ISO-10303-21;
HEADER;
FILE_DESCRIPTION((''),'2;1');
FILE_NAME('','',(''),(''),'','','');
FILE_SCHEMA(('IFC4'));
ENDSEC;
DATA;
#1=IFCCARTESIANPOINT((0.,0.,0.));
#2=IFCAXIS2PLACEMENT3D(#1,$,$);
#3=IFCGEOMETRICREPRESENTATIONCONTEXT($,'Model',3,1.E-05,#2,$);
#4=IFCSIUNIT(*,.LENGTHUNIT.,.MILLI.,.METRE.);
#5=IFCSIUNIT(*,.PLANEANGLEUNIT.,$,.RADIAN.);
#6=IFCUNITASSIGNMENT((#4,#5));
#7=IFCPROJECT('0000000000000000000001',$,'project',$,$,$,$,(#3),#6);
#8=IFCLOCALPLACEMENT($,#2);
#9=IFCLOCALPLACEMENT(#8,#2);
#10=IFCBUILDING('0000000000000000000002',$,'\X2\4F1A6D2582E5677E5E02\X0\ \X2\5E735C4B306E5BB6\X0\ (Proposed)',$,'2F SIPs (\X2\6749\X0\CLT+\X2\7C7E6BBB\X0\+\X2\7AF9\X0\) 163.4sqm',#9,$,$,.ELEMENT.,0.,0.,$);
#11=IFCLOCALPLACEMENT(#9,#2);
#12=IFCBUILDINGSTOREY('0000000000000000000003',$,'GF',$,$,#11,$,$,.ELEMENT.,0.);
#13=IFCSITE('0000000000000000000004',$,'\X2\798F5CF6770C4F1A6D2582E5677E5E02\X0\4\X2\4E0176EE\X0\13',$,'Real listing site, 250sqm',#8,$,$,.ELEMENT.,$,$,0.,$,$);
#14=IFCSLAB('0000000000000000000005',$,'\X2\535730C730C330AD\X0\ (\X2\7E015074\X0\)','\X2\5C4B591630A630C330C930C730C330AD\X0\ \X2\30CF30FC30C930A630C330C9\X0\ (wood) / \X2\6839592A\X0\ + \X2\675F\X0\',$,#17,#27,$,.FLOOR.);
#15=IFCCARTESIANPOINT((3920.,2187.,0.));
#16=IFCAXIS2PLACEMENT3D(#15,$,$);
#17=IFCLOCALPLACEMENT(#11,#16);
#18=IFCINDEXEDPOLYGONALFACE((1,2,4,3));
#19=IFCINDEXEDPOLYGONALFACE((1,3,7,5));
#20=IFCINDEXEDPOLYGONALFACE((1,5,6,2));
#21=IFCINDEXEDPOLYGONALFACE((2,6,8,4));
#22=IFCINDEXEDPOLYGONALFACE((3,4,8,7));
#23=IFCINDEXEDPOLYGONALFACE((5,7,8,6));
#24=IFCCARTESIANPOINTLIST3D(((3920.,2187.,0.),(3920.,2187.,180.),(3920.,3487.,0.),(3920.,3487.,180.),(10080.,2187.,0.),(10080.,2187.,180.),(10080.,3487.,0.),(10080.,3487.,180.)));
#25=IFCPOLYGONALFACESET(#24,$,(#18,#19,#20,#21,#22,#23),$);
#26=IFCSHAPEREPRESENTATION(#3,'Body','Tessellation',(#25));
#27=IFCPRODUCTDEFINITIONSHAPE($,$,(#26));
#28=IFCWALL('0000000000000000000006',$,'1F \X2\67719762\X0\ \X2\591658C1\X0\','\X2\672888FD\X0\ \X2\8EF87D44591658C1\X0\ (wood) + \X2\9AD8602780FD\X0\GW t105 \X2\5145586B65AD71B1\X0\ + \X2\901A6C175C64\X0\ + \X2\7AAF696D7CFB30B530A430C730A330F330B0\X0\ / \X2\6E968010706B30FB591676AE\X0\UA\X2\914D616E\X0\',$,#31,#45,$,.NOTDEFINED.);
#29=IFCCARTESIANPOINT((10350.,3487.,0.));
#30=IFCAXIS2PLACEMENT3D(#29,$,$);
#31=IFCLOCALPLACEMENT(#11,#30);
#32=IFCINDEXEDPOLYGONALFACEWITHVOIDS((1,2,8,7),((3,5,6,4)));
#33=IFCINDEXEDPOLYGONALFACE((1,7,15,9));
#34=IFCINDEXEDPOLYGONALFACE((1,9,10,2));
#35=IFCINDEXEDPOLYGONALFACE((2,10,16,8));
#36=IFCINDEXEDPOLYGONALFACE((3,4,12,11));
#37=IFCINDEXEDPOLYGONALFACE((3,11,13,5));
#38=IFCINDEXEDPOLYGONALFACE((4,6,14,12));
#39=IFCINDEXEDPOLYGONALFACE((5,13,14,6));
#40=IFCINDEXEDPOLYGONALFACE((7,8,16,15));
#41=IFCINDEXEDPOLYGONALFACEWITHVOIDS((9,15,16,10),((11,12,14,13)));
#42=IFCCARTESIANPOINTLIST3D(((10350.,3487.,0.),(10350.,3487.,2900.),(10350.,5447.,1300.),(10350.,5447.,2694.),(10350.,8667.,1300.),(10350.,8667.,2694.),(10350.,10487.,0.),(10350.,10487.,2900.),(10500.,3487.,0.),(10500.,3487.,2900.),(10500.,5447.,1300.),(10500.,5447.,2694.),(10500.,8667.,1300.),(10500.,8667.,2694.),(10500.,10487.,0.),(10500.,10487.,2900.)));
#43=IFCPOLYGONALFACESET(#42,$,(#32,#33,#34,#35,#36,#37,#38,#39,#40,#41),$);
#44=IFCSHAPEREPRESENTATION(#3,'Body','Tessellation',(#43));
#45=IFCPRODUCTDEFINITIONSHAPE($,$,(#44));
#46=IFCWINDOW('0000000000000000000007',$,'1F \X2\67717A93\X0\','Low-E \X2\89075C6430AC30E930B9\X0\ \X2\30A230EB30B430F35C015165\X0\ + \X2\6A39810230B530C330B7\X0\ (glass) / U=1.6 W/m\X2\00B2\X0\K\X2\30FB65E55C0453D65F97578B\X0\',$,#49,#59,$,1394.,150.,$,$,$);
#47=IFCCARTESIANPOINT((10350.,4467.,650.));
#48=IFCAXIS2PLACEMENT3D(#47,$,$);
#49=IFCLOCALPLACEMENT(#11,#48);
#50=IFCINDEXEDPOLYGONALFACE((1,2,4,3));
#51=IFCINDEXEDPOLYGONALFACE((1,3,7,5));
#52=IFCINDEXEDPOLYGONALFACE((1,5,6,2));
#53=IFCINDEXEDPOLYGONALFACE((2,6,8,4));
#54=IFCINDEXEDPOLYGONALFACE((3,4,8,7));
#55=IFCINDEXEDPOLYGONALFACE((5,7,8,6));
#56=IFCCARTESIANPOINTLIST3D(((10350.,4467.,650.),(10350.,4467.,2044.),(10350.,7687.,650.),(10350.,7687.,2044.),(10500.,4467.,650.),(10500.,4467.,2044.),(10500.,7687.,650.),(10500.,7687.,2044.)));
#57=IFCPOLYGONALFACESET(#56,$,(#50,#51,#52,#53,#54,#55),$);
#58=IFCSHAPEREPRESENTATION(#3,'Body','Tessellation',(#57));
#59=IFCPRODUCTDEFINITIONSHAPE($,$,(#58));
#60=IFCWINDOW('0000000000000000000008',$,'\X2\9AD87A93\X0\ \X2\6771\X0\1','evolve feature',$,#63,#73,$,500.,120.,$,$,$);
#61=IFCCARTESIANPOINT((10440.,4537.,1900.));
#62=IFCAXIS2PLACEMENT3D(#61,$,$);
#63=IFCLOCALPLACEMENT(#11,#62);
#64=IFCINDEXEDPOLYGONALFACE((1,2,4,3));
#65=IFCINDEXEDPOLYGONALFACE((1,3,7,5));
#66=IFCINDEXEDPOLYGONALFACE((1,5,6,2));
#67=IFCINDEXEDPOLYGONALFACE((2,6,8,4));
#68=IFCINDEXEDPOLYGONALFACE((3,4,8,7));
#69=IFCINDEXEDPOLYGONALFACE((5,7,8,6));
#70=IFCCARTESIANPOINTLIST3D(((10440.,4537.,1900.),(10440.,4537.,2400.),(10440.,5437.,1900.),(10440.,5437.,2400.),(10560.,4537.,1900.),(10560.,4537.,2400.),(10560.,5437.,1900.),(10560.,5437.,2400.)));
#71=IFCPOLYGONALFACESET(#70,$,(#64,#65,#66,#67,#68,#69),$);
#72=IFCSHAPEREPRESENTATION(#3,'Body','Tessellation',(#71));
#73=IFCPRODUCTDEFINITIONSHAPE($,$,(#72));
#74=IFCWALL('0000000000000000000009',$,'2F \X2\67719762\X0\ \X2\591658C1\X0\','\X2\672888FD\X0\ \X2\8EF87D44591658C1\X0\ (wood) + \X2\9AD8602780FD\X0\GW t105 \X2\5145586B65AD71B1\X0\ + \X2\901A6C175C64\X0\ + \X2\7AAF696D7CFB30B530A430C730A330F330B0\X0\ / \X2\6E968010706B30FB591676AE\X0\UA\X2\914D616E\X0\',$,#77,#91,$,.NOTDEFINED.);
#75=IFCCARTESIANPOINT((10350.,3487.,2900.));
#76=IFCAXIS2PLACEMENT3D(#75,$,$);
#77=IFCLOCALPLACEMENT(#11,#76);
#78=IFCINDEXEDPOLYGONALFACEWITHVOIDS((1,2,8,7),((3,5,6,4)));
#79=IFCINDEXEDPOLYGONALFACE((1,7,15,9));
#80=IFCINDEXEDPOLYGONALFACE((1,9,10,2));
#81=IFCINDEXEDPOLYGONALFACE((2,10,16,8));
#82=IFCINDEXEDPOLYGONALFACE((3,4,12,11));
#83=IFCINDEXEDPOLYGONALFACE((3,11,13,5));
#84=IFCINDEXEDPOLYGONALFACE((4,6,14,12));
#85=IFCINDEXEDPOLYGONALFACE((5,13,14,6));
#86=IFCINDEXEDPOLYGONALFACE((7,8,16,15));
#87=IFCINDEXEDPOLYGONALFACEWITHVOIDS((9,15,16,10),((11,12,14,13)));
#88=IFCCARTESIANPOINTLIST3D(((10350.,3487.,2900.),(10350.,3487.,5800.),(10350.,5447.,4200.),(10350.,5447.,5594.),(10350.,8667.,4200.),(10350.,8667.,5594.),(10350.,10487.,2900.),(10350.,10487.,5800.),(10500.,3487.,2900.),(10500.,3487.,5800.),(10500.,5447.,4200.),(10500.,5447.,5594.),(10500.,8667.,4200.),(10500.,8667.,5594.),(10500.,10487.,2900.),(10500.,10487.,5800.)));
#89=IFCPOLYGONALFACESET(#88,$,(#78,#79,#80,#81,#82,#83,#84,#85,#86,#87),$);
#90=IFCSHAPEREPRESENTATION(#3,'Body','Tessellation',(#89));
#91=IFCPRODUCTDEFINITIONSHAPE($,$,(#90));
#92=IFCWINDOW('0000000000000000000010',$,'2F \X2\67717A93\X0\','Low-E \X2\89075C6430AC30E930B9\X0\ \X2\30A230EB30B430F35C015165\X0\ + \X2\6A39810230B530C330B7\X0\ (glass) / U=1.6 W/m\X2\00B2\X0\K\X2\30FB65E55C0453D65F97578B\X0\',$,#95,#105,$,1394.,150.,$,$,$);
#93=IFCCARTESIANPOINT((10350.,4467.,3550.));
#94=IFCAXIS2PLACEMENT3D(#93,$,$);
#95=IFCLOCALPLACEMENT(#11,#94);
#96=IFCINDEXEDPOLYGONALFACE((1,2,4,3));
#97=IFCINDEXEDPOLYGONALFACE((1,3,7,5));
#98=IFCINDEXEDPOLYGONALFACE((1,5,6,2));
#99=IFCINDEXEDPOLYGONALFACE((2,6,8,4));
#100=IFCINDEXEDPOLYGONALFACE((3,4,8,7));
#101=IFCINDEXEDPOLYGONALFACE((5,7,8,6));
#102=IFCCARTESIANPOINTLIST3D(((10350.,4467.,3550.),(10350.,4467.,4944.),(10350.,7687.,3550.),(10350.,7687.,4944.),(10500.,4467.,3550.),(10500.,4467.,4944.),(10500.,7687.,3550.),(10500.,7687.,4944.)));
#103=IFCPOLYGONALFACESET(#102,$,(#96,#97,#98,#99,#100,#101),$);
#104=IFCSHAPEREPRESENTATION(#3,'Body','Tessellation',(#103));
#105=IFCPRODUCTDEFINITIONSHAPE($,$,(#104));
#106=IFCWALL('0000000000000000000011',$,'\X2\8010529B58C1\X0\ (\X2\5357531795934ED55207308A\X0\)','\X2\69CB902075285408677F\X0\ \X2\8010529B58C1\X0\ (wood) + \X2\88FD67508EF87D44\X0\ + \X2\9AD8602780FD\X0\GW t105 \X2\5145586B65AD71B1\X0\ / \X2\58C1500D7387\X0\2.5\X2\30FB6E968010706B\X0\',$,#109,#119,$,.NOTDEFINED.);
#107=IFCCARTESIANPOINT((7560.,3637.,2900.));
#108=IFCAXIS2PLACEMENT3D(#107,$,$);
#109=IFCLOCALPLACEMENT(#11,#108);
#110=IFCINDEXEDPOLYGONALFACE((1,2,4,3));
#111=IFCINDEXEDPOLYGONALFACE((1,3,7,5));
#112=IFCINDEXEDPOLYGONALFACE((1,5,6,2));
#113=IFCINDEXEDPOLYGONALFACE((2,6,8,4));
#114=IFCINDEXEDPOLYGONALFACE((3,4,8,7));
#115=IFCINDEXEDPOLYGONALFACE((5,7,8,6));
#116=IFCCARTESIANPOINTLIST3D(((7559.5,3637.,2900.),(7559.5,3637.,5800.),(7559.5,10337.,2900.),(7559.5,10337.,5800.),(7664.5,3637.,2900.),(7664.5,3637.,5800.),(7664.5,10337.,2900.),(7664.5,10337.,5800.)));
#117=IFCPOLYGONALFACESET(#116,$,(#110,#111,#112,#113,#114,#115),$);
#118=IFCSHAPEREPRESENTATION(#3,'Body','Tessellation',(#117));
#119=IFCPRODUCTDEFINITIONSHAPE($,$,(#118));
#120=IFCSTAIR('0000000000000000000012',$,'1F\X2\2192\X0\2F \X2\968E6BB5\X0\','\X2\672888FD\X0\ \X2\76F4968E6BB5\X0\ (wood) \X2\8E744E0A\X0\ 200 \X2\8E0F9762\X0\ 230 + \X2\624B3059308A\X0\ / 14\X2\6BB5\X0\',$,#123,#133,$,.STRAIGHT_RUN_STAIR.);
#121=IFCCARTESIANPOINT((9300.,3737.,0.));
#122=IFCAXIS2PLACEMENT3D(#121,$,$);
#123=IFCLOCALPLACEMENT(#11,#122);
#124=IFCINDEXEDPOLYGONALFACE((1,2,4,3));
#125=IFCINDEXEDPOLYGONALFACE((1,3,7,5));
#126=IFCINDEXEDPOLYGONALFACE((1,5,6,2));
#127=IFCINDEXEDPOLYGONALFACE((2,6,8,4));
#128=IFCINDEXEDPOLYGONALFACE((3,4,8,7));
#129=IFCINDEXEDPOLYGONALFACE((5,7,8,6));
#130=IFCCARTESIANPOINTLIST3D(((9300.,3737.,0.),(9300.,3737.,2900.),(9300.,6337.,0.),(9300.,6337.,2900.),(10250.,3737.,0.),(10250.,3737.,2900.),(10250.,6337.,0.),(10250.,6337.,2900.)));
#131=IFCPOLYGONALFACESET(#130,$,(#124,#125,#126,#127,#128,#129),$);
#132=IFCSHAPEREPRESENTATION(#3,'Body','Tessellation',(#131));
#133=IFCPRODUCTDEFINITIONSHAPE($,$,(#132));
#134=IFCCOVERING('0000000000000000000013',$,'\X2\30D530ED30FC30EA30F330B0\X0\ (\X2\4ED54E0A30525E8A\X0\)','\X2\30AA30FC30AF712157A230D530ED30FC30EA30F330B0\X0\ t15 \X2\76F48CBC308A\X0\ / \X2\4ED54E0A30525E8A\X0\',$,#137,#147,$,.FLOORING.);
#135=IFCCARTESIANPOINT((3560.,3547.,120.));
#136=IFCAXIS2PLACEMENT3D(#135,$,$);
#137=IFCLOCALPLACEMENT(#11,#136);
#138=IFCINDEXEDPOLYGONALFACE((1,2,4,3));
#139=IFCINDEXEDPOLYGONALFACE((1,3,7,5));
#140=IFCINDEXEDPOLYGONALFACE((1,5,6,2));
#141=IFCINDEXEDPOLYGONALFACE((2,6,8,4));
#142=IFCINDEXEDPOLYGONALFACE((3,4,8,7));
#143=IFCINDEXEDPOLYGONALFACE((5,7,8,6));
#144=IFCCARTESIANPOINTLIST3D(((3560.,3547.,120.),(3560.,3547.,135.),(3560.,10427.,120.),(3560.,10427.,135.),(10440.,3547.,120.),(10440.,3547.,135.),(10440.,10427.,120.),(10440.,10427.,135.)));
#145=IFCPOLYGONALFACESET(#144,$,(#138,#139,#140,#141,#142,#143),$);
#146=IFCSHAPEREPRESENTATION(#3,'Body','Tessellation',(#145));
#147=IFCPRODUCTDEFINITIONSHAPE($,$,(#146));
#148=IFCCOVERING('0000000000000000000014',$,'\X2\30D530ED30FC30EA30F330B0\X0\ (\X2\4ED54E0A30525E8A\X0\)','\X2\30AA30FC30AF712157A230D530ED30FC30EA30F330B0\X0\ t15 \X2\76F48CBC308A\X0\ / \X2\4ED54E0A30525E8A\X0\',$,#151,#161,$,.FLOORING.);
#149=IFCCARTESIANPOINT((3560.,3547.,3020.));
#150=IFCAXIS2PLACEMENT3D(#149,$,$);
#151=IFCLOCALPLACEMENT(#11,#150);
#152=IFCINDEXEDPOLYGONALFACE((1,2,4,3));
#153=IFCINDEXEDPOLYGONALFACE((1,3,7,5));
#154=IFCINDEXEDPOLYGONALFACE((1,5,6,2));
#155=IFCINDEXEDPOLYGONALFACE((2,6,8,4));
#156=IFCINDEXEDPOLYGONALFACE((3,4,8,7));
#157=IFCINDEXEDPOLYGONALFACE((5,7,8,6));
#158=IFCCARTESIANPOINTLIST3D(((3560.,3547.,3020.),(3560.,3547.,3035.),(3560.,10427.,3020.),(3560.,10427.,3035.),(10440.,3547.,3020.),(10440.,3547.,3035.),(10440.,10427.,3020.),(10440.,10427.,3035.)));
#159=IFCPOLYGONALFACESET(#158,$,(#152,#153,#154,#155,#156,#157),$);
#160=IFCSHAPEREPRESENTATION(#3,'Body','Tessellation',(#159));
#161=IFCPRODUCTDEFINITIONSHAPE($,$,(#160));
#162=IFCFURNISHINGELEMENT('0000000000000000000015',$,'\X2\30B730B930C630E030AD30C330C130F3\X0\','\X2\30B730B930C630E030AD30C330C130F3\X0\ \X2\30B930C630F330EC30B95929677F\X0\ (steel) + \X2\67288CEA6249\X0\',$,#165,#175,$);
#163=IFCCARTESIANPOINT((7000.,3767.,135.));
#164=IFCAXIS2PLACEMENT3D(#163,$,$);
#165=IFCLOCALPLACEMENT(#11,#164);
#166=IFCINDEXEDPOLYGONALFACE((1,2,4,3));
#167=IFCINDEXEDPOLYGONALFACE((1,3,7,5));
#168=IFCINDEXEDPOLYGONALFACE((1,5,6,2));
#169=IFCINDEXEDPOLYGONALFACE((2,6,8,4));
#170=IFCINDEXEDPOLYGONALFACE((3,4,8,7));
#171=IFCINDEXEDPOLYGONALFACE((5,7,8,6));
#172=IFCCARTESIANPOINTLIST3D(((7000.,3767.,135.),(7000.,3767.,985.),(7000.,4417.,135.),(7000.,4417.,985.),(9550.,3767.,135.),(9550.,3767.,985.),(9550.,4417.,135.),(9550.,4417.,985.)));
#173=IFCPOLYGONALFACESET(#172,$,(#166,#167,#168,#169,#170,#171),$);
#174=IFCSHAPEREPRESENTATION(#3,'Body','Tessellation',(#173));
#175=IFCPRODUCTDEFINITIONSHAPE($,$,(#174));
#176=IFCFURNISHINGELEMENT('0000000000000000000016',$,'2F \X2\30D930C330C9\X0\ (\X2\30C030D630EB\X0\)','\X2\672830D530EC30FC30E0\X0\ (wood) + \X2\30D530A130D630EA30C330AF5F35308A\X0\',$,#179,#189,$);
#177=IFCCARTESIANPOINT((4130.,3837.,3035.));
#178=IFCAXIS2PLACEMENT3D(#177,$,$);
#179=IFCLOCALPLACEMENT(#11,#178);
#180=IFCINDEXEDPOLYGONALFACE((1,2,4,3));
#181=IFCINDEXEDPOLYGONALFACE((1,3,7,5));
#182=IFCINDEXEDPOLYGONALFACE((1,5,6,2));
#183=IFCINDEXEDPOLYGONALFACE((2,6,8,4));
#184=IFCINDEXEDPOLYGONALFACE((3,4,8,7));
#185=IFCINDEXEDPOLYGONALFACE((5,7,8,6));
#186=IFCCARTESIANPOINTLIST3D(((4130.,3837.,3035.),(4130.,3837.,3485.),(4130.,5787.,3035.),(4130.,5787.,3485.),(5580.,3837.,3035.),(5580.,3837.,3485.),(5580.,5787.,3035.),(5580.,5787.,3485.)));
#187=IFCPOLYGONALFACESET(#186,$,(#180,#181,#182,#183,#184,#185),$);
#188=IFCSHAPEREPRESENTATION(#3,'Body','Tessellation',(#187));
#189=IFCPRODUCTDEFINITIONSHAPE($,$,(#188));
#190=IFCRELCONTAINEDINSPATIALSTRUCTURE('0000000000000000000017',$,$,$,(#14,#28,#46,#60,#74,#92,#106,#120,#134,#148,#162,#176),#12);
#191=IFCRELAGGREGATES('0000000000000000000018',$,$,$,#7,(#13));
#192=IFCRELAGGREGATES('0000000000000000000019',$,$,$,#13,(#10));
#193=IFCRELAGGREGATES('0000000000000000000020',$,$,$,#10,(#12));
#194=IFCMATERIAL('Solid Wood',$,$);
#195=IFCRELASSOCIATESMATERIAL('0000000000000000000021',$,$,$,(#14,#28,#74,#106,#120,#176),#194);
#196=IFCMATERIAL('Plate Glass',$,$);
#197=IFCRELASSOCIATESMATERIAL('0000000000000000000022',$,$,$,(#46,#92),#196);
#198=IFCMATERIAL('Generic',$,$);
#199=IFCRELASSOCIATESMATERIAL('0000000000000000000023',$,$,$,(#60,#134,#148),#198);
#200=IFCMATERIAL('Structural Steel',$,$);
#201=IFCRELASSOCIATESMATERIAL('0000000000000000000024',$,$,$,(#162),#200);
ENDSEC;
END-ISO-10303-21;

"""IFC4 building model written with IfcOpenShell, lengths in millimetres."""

from ifc_helpers import new_model, si_unit, frame, frame_2d, origin, place, context, project, spatial, rectangle, extrude, material, element, fill, save


model = new_model("IFC4")

# Units and contexts
model_context = context("Model", 3, precision=1e-05, world=origin())
ifc_project = project(units=[si_unit("LENGTHUNIT", "METRE", prefix="MILLI"), si_unit("PLANEANGLEUNIT", "RADIAN")], contexts=[model_context])

# Site, building, storey
site_placement = place(None, origin())
site = spatial("IfcSite", under=ifc_project, at=site_placement, Name="福島県会津若松市4丁目13", ObjectType="Real listing site, 250sqm", CompositionType="ELEMENT", RefElevation=0.0)
building_placement = place(site_placement, origin())
building = spatial("IfcBuilding", under=site, at=building_placement, Name="会津若松市 平屋の家 (Proposed)", ObjectType="2F SIPs (杉CLT+籾殻+竹) 163.4sqm", CompositionType="ELEMENT", ElevationOfRefHeight=0.0, ElevationOfTerrain=0.0)
storey_placement = place(building_placement, origin())
storey = spatial("IfcBuildingStorey", under=building, at=storey_placement, Name="GF", CompositionType="ELEMENT", Elevation=0.0)

# Slab
ifc_material_1 = material(Name="Solid Wood")
slab_placement = place(storey_placement, frame((3920.0, 2187.0, 0.0)))
element("IfcSlab", 1, at=slab_placement, inside=storey, material=ifc_material_1, Name="南デッキ (縁側)", Description="屋外ウッドデッキ ハードウッド (wood) / 根太 + 束", PredefinedType="FLOOR", context=model_context, shape_type="SweptSolid", body=[
    extrude(rectangle(XDim=6160.0, YDim=1300.0, at=frame_2d((3080.0, 650.0))), frame((3920.0, 2187.0, 0.0)), (0.0, 0.0, 1.0), 180.0),
])

# Wall, openings, windows
wall_1_placement = place(storey_placement, frame((10350.0, 3487.0, 0.0)))
wall_1 = element("IfcWall", 2, at=wall_1_placement, inside=storey, material=ifc_material_1, Name="1F 東面 外壁", Description="木製 軸組外壁 (wood) + 高性能GW t105 充填断熱 + 通気層 + 窯業系サイディング / 準耐火・外皮UA配慮", PredefinedType="NOTDEFINED", context=model_context, shape_type="SweptSolid", body=[
    extrude(rectangle(XDim=150.0, YDim=7000.0, at=frame_2d((75.0, 3500.0))), frame((10350.0, 3487.0, 0.0)), (0.0, 0.0, 1.0), 2900.0),
])
opening_1_placement = place(storey_placement, frame((10350.0, 4467.0, 650.0)))
opening_1 = element("IfcOpeningElement", 3, at=opening_1_placement, cuts=wall_1, PredefinedType="NOTDEFINED", context=model_context, shape_type="SweptSolid", body=[
    extrude(rectangle(XDim=150.0, YDim=3220.0, at=frame_2d((75.0, 1610.0))), frame((10350.0, 4467.0, 650.0)), (0.0, 0.0, 1.0), 1394.0),
])
opening_2_placement = place(storey_placement, frame((10440.0, 4537.0, 1900.0)))
opening_2 = element("IfcOpeningElement", 4, at=opening_2_placement, cuts=wall_1, PredefinedType="NOTDEFINED", context=model_context, shape_type="SweptSolid", body=[
    extrude(rectangle(XDim=120.0, YDim=900.0, at=frame_2d((60.0, 450.0))), frame((10440.0, 4537.0, 1900.0)), (0.0, 0.0, 1.0), 500.0),
])
ifc_material_2 = material(Name="Plate Glass")
window_1_placement = place(storey_placement, frame((10350.0, 4467.0, 650.0)))
window_1 = element("IfcWindow", 5, at=window_1_placement, inside=storey, material=ifc_material_2, Name="1F 東窓", Description="Low-E 複層ガラス アルゴン封入 + 樹脂サッシ (glass) / U=1.6 W/m²K・日射取得型", OverallHeight=1394.0, OverallWidth=150.0, context=model_context, shape_type="SweptSolid", body=[
    extrude(rectangle(XDim=150.0, YDim=3220.0, at=frame_2d((75.0, 1610.0))), frame((10350.0, 4467.0, 650.0)), (0.0, 0.0, 1.0), 1394.0),
])
fill(opening_1, window_1)
ifc_material_3 = material(Name="Generic")
window_2_placement = place(storey_placement, frame((10440.0, 4537.0, 1900.0)))
window_2 = element("IfcWindow", 6, at=window_2_placement, inside=storey, material=ifc_material_3, Name="高窓 東1", Description="evolve feature", OverallHeight=500.0, OverallWidth=120.0, context=model_context, shape_type="SweptSolid", body=[
    extrude(rectangle(XDim=120.0, YDim=900.0, at=frame_2d((60.0, 450.0))), frame((10440.0, 4537.0, 1900.0)), (0.0, 0.0, 1.0), 500.0),
])
fill(opening_2, window_2)

# Wall, opening, window
wall_2_placement = place(storey_placement, frame((10350.0, 3487.0, 2900.0)))
wall_2 = element("IfcWall", 7, at=wall_2_placement, inside=storey, material=ifc_material_1, Name="2F 東面 外壁", Description="木製 軸組外壁 (wood) + 高性能GW t105 充填断熱 + 通気層 + 窯業系サイディング / 準耐火・外皮UA配慮", PredefinedType="NOTDEFINED", context=model_context, shape_type="SweptSolid", body=[
    extrude(rectangle(XDim=150.0, YDim=7000.0, at=frame_2d((75.0, 3500.0))), frame((10350.0, 3487.0, 2900.0)), (0.0, 0.0, 1.0), 2900.0),
])
opening_3_placement = place(storey_placement, frame((10350.0, 4467.0, 3550.0)))
opening_3 = element("IfcOpeningElement", 8, at=opening_3_placement, cuts=wall_2, PredefinedType="NOTDEFINED", context=model_context, shape_type="SweptSolid", body=[
    extrude(rectangle(XDim=150.0, YDim=3220.0, at=frame_2d((75.0, 1610.0))), frame((10350.0, 4467.0, 3550.0)), (0.0, 0.0, 1.0), 1394.0),
])
window_3_placement = place(storey_placement, frame((10350.0, 4467.0, 3550.0)))
window_3 = element("IfcWindow", 9, at=window_3_placement, inside=storey, material=ifc_material_2, Name="2F 東窓", Description="Low-E 複層ガラス アルゴン封入 + 樹脂サッシ (glass) / U=1.6 W/m²K・日射取得型", OverallHeight=1394.0, OverallWidth=150.0, context=model_context, shape_type="SweptSolid", body=[
    extrude(rectangle(XDim=150.0, YDim=3220.0, at=frame_2d((75.0, 1610.0))), frame((10350.0, 4467.0, 3550.0)), (0.0, 0.0, 1.0), 1394.0),
])
fill(opening_3, window_3)

# Wall
wall_3_placement = place(storey_placement, frame((7560.0, 3637.0, 2900.0)))
element("IfcWall", 10, at=wall_3_placement, inside=storey, material=ifc_material_1, Name="耐力壁 (南北間仕切り)", Description="構造用合板 耐力壁 (wood) + 製材軸組 + 高性能GW t105 充填断熱 / 壁倍率2.5・準耐火", PredefinedType="NOTDEFINED", context=model_context, shape_type="SweptSolid", body=[
    extrude(rectangle(XDim=105.0, YDim=6700.0, at=frame_2d((52.0, 3350.0))), frame((7560.0, 3637.0, 2900.0)), (0.0, 0.0, 1.0), 2900.0),
])

# Stair
stair_placement = place(storey_placement, frame((9300.0, 3737.0, 0.0)))
element("IfcStair", 11, at=stair_placement, inside=storey, material=ifc_material_1, Name="1F→2F 階段", Description="木製 直階段 (wood) 蹴上 200 踏面 230 + 手すり / 14段", PredefinedType="STRAIGHT_RUN_STAIR", context=model_context, shape_type="SweptSolid", body=[
    extrude(rectangle(XDim=950.0, YDim=2600.0, at=frame_2d((475.0, 1300.0))), frame((9300.0, 3737.0, 0.0)), (0.0, 0.0, 1.0), 2900.0),
])

# Coverings
covering_1_placement = place(storey_placement, frame((3560.0, 3547.0, 120.0)))
element("IfcCovering", 12, at=covering_1_placement, inside=storey, material=ifc_material_3, Name="フローリング (仕上げ床)", Description="オーク無垢フローリング t15 直貼り / 仕上げ床", PredefinedType="FLOORING", context=model_context, shape_type="SweptSolid", body=[
    extrude(rectangle(XDim=6880.0, YDim=6880.0, at=frame_2d((3440.0, 3440.0))), frame((3560.0, 3547.0, 120.0)), (0.0, 0.0, 1.0), 15.0),
])
covering_2_placement = place(storey_placement, frame((3560.0, 3547.0, 3020.0)))
element("IfcCovering", 13, at=covering_2_placement, inside=storey, material=ifc_material_3, Name="フローリング (仕上げ床)", Description="オーク無垢フローリング t15 直貼り / 仕上げ床", PredefinedType="FLOORING", context=model_context, shape_type="SweptSolid", body=[
    extrude(rectangle(XDim=6880.0, YDim=6880.0, at=frame_2d((3440.0, 3440.0))), frame((3560.0, 3547.0, 3020.0)), (0.0, 0.0, 1.0), 15.0),
])

# Furnishing elements
ifc_material_4 = material(Name="Structural Steel")
furnishing_1_placement = place(storey_placement, frame((7000.0, 3767.0, 135.0)))
element("IfcFurnishingElement", 14, at=furnishing_1_placement, inside=storey, material=ifc_material_4, Name="システムキッチン", Description="システムキッチン ステンレス天板 (steel) + 木質扉", context=model_context, shape_type="SweptSolid", body=[
    extrude(rectangle(XDim=2550.0, YDim=650.0, at=frame_2d((1275.0, 325.0))), frame((7000.0, 3767.0, 135.0)), (0.0, 0.0, 1.0), 850.0),
])
furnishing_2_placement = place(storey_placement, frame((4130.0, 3837.0, 3035.0)))
element("IfcFurnishingElement", 15, at=furnishing_2_placement, inside=storey, material=ifc_material_1, Name="2F ベッド (ダブル)", Description="木フレーム (wood) + ファブリック張り", context=model_context, shape_type="SweptSolid", body=[
    extrude(rectangle(XDim=1450.0, YDim=1950.0, at=frame_2d((725.0, 975.0))), frame((4130.0, 3837.0, 3035.0)), (0.0, 0.0, 1.0), 450.0),
])

save(model, "model.ifc")
